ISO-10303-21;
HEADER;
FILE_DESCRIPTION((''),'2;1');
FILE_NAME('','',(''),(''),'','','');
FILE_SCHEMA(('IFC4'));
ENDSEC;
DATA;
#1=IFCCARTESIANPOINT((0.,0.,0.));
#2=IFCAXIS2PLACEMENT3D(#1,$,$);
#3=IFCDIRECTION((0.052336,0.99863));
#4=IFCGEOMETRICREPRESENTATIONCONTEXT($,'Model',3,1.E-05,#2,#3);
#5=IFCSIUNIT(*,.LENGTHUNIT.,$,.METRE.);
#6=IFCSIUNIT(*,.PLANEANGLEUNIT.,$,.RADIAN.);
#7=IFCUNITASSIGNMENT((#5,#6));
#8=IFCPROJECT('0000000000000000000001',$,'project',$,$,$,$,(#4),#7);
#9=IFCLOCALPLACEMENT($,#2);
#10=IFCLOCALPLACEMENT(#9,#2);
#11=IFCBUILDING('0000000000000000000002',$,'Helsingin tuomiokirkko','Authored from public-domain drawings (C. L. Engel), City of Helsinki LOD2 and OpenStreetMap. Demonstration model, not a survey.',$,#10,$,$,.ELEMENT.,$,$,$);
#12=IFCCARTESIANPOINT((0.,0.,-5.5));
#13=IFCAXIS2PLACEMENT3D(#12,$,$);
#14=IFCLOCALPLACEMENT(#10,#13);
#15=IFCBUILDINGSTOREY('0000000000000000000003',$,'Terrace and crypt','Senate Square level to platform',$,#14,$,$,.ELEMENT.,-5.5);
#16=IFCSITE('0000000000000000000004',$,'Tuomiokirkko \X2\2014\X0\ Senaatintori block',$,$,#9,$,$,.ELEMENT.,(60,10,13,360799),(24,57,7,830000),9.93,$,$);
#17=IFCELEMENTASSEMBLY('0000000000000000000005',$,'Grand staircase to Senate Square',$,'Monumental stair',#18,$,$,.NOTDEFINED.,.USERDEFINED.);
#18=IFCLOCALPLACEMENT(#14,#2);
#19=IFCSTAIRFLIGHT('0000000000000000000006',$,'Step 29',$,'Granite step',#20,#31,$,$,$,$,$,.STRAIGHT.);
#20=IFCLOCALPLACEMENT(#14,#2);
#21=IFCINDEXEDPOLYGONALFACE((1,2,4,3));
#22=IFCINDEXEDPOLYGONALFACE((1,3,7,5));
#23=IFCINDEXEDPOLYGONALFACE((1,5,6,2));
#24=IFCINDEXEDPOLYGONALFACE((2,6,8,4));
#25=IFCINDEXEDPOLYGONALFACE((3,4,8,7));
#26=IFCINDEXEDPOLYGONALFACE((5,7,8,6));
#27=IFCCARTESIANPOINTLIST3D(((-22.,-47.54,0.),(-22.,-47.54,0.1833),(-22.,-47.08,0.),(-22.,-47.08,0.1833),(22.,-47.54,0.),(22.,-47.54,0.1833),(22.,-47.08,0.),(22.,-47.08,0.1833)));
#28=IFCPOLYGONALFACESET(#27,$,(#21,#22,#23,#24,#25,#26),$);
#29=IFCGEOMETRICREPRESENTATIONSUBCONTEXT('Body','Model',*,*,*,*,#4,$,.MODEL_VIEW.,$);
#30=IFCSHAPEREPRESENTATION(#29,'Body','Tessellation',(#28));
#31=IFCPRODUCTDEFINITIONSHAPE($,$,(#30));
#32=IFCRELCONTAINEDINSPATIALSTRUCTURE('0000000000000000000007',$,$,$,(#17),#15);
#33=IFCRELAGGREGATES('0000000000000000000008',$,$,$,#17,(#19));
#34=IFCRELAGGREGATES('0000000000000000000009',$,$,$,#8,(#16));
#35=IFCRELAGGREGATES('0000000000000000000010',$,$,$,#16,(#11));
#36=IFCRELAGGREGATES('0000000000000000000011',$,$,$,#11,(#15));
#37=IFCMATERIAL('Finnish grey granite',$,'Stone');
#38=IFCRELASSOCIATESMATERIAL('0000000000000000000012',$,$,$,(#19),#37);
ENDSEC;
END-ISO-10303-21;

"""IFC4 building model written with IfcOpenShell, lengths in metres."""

from ifc_helpers import new_model, si_unit, direction, frame, origin, origin_2d_with_axis, place, context, subcontext, project, spatial, rectangle, extrude, material, element, aggregate, save


model = new_model("IFC4")

# Units and contexts
model_context = context("Model", 3, precision=1e-05, world=origin(), true_north=direction((0.052336, 0.99863)))
body_context = subcontext(model_context, "Body", "Model", "MODEL_VIEW")
ifc_project = project(units=[si_unit("LENGTHUNIT", "METRE"), si_unit("PLANEANGLEUNIT", "RADIAN")], contexts=[model_context])

# Site, building, storey
site_placement = place(None, origin())
site = spatial("IfcSite", under=ifc_project, at=site_placement, Name="Tuomiokirkko — Senaatintori block", CompositionType="ELEMENT", RefLatitude=(60, 10, 13, 360799), RefLongitude=(24, 57, 7, 830000), RefElevation=9.93)
building_placement = place(site_placement, origin())
building = spatial("IfcBuilding", under=site, at=building_placement, Name="Helsingin tuomiokirkko", Description="Authored from public-domain drawings (C. L. Engel), City of Helsinki LOD2 and OpenStreetMap. Demonstration model, not a survey.", CompositionType="ELEMENT")
storey_placement = place(building_placement, frame((0.0, 0.0, -5.5)))
storey = spatial("IfcBuildingStorey", under=building, at=storey_placement, Name="Terrace and crypt", Description="Senate Square level to platform", CompositionType="ELEMENT", Elevation=-5.5)

# Element assembly, stair flight
assembly_placement = place(building_placement, origin())
assembly = element("IfcElementAssembly", 1, at=assembly_placement, inside=storey, Name="Grand staircase to Senate Square", ObjectType="Monumental stair", AssemblyPlace="NOTDEFINED", PredefinedType="USERDEFINED")
ifc_material_1 = material(Name="Finnish grey granite", Category="Stone")
stair_flight_1_placement = place(building_placement, origin())
stair_flight_1 = element("IfcStairFlight", 2, at=stair_flight_1_placement, material=ifc_material_1, Name="Step 29", ObjectType="Granite step", PredefinedType="STRAIGHT", context=body_context, shape_type="SweptSolid", body=[
    extrude(rectangle(XDim=44.0, YDim=0.46, at=origin_2d_with_axis()), frame((0.0, -47.31, -5.5)), (0.0, 0.0, 1.0), 0.1833),
])
aggregate(assembly, [stair_flight_1])

save(model, "model.ifc")
